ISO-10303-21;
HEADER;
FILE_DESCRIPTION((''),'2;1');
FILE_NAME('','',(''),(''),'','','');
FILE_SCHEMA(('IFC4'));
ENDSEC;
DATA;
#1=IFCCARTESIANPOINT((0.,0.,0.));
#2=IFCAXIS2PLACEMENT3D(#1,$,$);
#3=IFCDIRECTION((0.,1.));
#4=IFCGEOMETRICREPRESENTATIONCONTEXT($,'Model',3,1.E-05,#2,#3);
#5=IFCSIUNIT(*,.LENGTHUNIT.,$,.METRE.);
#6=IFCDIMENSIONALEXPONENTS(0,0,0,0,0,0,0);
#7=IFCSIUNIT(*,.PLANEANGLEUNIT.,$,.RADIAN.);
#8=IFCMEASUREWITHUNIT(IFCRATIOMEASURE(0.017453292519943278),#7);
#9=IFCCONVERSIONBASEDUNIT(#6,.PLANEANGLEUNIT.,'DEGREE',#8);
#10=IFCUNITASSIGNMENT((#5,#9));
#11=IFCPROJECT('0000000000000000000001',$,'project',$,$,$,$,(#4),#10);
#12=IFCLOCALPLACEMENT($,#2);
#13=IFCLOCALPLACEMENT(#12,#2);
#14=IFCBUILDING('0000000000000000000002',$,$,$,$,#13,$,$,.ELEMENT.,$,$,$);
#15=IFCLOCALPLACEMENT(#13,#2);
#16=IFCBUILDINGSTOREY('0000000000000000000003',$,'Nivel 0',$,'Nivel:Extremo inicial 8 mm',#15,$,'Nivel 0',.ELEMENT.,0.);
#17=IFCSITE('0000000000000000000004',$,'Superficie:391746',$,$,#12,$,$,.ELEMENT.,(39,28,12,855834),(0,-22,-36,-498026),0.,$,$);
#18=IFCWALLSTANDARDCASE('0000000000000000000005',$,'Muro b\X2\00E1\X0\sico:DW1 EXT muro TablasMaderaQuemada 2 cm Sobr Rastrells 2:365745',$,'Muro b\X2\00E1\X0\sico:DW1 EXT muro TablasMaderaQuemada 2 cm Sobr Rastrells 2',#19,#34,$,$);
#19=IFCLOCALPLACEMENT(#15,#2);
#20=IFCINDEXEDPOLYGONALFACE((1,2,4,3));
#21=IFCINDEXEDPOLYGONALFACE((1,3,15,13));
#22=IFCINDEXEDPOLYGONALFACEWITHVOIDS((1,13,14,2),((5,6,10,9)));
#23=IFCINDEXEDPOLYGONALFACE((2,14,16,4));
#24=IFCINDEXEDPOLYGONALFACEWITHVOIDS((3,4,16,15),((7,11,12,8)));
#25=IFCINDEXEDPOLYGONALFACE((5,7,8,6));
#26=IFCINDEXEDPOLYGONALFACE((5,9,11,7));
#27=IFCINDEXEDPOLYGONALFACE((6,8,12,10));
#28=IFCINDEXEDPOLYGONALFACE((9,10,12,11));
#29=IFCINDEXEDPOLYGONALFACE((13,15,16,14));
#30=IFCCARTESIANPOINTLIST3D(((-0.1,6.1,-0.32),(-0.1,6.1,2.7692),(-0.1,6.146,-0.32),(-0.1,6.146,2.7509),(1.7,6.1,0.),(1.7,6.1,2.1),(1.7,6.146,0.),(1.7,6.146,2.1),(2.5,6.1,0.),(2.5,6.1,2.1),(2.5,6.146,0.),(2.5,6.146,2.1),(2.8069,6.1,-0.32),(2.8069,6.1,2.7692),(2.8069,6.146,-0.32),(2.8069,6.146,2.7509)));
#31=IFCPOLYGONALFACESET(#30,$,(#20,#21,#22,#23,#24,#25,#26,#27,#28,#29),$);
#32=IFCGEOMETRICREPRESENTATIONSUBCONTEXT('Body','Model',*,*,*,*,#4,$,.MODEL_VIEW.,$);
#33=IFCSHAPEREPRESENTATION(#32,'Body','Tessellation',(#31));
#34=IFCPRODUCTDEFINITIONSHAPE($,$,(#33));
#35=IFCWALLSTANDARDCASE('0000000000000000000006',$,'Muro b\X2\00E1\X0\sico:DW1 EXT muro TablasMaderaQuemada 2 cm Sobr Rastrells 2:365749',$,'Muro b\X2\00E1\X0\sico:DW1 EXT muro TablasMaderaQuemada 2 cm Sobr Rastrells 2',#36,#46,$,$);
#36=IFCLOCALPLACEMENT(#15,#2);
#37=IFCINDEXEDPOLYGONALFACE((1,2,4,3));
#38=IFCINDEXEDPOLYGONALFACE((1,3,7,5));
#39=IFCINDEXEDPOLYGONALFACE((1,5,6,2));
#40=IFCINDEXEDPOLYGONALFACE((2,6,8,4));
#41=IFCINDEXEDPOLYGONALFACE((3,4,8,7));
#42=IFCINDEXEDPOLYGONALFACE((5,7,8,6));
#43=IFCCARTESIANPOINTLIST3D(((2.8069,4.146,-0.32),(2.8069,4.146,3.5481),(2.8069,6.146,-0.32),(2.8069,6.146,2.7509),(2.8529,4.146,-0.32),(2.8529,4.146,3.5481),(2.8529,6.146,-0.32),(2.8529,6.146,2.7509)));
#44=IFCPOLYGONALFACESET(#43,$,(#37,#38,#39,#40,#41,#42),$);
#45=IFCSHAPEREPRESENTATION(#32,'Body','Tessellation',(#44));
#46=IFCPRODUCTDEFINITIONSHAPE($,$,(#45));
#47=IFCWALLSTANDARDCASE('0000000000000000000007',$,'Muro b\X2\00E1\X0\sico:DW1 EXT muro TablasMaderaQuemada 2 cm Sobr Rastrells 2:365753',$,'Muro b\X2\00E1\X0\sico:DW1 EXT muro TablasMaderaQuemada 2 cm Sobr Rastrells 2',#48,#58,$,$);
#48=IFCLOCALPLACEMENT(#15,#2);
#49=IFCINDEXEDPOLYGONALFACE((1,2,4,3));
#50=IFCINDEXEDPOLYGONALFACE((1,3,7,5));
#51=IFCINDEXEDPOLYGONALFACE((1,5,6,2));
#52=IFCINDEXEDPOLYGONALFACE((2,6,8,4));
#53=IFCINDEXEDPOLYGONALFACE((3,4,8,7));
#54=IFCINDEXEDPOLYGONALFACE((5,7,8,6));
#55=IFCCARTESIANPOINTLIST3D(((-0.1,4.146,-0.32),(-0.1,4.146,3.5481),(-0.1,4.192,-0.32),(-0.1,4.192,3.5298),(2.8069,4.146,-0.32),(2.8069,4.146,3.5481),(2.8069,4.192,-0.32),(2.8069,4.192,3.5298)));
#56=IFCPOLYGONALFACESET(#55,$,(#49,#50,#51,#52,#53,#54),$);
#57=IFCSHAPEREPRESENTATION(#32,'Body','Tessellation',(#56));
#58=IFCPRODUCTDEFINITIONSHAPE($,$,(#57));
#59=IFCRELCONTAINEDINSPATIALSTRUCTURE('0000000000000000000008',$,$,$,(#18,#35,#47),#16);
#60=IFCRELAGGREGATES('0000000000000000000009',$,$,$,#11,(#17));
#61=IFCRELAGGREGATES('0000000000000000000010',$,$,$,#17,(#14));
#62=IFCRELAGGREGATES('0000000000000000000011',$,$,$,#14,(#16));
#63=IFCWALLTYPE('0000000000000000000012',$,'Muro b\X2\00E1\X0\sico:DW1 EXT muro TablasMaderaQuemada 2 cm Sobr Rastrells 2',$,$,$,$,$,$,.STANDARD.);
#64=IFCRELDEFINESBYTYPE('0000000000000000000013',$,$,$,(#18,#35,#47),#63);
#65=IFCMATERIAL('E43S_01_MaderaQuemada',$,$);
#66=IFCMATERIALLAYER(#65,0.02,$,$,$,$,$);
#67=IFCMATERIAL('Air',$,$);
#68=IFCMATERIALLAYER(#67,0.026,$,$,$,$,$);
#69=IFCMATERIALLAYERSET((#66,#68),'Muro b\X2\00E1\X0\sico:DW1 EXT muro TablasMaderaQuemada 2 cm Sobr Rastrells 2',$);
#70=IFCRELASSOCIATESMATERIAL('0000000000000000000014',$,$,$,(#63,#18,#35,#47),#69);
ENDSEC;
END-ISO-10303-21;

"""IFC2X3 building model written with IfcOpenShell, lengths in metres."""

from ifc_helpers import new_model, entity, si_unit, converted_unit, direction, frame, frame_2d, origin, place, context, subcontext, project, spatial, polyline, rectangle, extrude, clip, bounded_halfspace, material, layer, layer_set, layer_usage, type_object, element, save


model = new_model("IFC2X3")

# Units and contexts
model_context = context("Model", 3, precision=1e-05, world=origin(), true_north=direction((0.0, 1.0)))
body_context = subcontext(model_context, "Body", "Model", "MODEL_VIEW")
ifc_project = project(units=[si_unit("LENGTHUNIT", "METRE"), converted_unit("PLANEANGLEUNIT", "DEGREE", entity("IfcRatioMeasure", 0.017453292519943278), si_unit("PLANEANGLEUNIT", "RADIAN"), dimensions=[0, 0, 0, 0, 0, 0, 0])], contexts=[model_context])

# Site, building, storey
site_placement = place(None, origin())
site = spatial("IfcSite", under=ifc_project, at=site_placement, Name="Superficie:391746", CompositionType="ELEMENT", RefLatitude=(39, 28, 12, 855834), RefLongitude=(0, -22, -36, -498026), RefElevation=0.0)
building_placement = place(site_placement, origin())
building = spatial("IfcBuilding", under=site, at=building_placement, CompositionType="ELEMENT")
storey_placement = place(building_placement, origin())
storey = spatial("IfcBuildingStorey", under=building, at=storey_placement, Name="Nivel 0", ObjectType="Nivel:Extremo inicial 8 mm", LongName="Nivel 0", CompositionType="ELEMENT", Elevation=0.0)

# Shared definitions
ifc_material_1 = material(Name="E43S_01_MaderaQuemada")
ifc_layer_1 = layer(ifc_material_1, 0.02)
ifc_material_2 = material(Name="Air")
ifc_layer_2 = layer(ifc_material_2, 0.026)
ifc_layer_set_1 = layer_set([ifc_layer_1, ifc_layer_2], Name="Muro básico:DW1 EXT muro TablasMaderaQuemada 2 cm Sobr Rastrells 2")
wall_type_1 = type_object("IfcWallType", Name="Muro básico:DW1 EXT muro TablasMaderaQuemada 2 cm Sobr Rastrells 2", PredefinedType="STANDARD", material=ifc_layer_set_1)

# Wall, opening
ifc_layer_usage_1 = layer_usage(ifc_layer_set_1, "AXIS2", "NEGATIVE", 0.023)
wall_1_placement = place(storey_placement, frame((-0.1, 6.123, -0.32)))
wall_1 = element("IfcWallStandardCase", 1, at=wall_1_placement, inside=storey, type_object=wall_type_1, material=ifc_layer_usage_1, Name="Muro básico:DW1 EXT muro TablasMaderaQuemada 2 cm Sobr Rastrells 2:365745", ObjectType="Muro básico:DW1 EXT muro TablasMaderaQuemada 2 cm Sobr Rastrells 2", context=body_context, shape_type="Clipping", body=[
    clip(extrude(rectangle(XDim=2.9069, YDim=0.046, at=frame_2d((1.4535, 0.0), x_axis=(1.0, 0.0))), origin(), (0.0, 0.0, 1.0), 3.0892), bounded_halfspace(frame((0.0, -0.023, 3.0892), z_axis=(0.0, 0.370288, 0.928917), x_axis=(-1.0, 0.0, 0.0)), False, frame((0.0, -0.023, 3.0892)), polyline([(0.0, 0.0), (2.9069, 0.0), (2.9069, 0.046), (0.0, 0.046), (0.0, 0.0)]))),
])
opening_1_placement = place(wall_1_placement, frame((1.8, -1.547, 0.32)))
element("IfcOpeningElement", 2, at=opening_1_placement, cuts=wall_1, ObjectType="Opening", context=body_context, shape_type="SweptSolid", body=[
    extrude(rectangle(XDim=2.1, YDim=0.8, at=frame_2d((0.0, 0.0), x_axis=(1.0, 0.0))), frame((0.4, 0.0, 1.05), z_axis=(0.0, 1.0, 0.0), x_axis=(0.0, 0.0, -1.0)), (0.0, 0.0, 1.0), 3.048),
])

# Walls
ifc_layer_usage_2 = layer_usage(ifc_layer_set_1, "AXIS2", "NEGATIVE", 0.023)
wall_2_placement = place(storey_placement, frame((2.8299, 6.146, -0.32), z_axis=(0.0, 0.0, 1.0), x_axis=(0.0, -1.0, 0.0)))
element("IfcWallStandardCase", 3, at=wall_2_placement, inside=storey, type_object=wall_type_1, material=ifc_layer_usage_2, Name="Muro básico:DW1 EXT muro TablasMaderaQuemada 2 cm Sobr Rastrells 2:365749", ObjectType="Muro básico:DW1 EXT muro TablasMaderaQuemada 2 cm Sobr Rastrells 2", context=body_context, shape_type="Clipping", body=[
    clip(extrude(rectangle(XDim=2.0, YDim=0.046, at=frame_2d((1.0, 0.0), x_axis=(-1.0, 0.0))), origin(), (0.0, 0.0, 1.0), 3.8681), bounded_halfspace(frame((0.0, -0.023, 3.0709), z_axis=(-0.370288, 0.0, 0.928917), x_axis=(0.0, -1.0, 0.0)), False, frame((0.0, -0.023, 3.0709)), polyline([(0.0, 0.0), (0.046, 0.0), (1.954, 0.0), (2.0, 0.0), (2.0, 0.046), (0.0, 0.046), (0.0, 0.0)]))),
])
ifc_layer_usage_3 = layer_usage(ifc_layer_set_1, "AXIS2", "NEGATIVE", 0.023)
wall_3_placement = place(storey_placement, frame((2.8069, 4.169, -0.32), z_axis=(0.0, 0.0, 1.0), x_axis=(-1.0, 0.0, 0.0)))
element("IfcWallStandardCase", 4, at=wall_3_placement, inside=storey, type_object=wall_type_1, material=ifc_layer_usage_3, Name="Muro básico:DW1 EXT muro TablasMaderaQuemada 2 cm Sobr Rastrells 2:365753", ObjectType="Muro básico:DW1 EXT muro TablasMaderaQuemada 2 cm Sobr Rastrells 2", context=body_context, shape_type="Clipping", body=[
    clip(extrude(rectangle(XDim=2.9069, YDim=0.046, at=frame_2d((1.4535, 0.0), x_axis=(-1.0, 0.0))), origin(), (0.0, 0.0, 1.0), 3.8681), bounded_halfspace(frame((0.0, -0.023, 3.8498), z_axis=(0.0, -0.370288, 0.928917), x_axis=(1.0, 0.0, 0.0)), False, frame((0.0, -0.023, 3.8498)), polyline([(0.0, 0.0), (0.2, 0.0), (2.7069, 0.0), (2.8069, 0.0), (2.9069, 0.0), (2.9069, 0.046), (0.0, 0.046), (0.0, 0.0)]))),
])

save(model, "model.ifc")
